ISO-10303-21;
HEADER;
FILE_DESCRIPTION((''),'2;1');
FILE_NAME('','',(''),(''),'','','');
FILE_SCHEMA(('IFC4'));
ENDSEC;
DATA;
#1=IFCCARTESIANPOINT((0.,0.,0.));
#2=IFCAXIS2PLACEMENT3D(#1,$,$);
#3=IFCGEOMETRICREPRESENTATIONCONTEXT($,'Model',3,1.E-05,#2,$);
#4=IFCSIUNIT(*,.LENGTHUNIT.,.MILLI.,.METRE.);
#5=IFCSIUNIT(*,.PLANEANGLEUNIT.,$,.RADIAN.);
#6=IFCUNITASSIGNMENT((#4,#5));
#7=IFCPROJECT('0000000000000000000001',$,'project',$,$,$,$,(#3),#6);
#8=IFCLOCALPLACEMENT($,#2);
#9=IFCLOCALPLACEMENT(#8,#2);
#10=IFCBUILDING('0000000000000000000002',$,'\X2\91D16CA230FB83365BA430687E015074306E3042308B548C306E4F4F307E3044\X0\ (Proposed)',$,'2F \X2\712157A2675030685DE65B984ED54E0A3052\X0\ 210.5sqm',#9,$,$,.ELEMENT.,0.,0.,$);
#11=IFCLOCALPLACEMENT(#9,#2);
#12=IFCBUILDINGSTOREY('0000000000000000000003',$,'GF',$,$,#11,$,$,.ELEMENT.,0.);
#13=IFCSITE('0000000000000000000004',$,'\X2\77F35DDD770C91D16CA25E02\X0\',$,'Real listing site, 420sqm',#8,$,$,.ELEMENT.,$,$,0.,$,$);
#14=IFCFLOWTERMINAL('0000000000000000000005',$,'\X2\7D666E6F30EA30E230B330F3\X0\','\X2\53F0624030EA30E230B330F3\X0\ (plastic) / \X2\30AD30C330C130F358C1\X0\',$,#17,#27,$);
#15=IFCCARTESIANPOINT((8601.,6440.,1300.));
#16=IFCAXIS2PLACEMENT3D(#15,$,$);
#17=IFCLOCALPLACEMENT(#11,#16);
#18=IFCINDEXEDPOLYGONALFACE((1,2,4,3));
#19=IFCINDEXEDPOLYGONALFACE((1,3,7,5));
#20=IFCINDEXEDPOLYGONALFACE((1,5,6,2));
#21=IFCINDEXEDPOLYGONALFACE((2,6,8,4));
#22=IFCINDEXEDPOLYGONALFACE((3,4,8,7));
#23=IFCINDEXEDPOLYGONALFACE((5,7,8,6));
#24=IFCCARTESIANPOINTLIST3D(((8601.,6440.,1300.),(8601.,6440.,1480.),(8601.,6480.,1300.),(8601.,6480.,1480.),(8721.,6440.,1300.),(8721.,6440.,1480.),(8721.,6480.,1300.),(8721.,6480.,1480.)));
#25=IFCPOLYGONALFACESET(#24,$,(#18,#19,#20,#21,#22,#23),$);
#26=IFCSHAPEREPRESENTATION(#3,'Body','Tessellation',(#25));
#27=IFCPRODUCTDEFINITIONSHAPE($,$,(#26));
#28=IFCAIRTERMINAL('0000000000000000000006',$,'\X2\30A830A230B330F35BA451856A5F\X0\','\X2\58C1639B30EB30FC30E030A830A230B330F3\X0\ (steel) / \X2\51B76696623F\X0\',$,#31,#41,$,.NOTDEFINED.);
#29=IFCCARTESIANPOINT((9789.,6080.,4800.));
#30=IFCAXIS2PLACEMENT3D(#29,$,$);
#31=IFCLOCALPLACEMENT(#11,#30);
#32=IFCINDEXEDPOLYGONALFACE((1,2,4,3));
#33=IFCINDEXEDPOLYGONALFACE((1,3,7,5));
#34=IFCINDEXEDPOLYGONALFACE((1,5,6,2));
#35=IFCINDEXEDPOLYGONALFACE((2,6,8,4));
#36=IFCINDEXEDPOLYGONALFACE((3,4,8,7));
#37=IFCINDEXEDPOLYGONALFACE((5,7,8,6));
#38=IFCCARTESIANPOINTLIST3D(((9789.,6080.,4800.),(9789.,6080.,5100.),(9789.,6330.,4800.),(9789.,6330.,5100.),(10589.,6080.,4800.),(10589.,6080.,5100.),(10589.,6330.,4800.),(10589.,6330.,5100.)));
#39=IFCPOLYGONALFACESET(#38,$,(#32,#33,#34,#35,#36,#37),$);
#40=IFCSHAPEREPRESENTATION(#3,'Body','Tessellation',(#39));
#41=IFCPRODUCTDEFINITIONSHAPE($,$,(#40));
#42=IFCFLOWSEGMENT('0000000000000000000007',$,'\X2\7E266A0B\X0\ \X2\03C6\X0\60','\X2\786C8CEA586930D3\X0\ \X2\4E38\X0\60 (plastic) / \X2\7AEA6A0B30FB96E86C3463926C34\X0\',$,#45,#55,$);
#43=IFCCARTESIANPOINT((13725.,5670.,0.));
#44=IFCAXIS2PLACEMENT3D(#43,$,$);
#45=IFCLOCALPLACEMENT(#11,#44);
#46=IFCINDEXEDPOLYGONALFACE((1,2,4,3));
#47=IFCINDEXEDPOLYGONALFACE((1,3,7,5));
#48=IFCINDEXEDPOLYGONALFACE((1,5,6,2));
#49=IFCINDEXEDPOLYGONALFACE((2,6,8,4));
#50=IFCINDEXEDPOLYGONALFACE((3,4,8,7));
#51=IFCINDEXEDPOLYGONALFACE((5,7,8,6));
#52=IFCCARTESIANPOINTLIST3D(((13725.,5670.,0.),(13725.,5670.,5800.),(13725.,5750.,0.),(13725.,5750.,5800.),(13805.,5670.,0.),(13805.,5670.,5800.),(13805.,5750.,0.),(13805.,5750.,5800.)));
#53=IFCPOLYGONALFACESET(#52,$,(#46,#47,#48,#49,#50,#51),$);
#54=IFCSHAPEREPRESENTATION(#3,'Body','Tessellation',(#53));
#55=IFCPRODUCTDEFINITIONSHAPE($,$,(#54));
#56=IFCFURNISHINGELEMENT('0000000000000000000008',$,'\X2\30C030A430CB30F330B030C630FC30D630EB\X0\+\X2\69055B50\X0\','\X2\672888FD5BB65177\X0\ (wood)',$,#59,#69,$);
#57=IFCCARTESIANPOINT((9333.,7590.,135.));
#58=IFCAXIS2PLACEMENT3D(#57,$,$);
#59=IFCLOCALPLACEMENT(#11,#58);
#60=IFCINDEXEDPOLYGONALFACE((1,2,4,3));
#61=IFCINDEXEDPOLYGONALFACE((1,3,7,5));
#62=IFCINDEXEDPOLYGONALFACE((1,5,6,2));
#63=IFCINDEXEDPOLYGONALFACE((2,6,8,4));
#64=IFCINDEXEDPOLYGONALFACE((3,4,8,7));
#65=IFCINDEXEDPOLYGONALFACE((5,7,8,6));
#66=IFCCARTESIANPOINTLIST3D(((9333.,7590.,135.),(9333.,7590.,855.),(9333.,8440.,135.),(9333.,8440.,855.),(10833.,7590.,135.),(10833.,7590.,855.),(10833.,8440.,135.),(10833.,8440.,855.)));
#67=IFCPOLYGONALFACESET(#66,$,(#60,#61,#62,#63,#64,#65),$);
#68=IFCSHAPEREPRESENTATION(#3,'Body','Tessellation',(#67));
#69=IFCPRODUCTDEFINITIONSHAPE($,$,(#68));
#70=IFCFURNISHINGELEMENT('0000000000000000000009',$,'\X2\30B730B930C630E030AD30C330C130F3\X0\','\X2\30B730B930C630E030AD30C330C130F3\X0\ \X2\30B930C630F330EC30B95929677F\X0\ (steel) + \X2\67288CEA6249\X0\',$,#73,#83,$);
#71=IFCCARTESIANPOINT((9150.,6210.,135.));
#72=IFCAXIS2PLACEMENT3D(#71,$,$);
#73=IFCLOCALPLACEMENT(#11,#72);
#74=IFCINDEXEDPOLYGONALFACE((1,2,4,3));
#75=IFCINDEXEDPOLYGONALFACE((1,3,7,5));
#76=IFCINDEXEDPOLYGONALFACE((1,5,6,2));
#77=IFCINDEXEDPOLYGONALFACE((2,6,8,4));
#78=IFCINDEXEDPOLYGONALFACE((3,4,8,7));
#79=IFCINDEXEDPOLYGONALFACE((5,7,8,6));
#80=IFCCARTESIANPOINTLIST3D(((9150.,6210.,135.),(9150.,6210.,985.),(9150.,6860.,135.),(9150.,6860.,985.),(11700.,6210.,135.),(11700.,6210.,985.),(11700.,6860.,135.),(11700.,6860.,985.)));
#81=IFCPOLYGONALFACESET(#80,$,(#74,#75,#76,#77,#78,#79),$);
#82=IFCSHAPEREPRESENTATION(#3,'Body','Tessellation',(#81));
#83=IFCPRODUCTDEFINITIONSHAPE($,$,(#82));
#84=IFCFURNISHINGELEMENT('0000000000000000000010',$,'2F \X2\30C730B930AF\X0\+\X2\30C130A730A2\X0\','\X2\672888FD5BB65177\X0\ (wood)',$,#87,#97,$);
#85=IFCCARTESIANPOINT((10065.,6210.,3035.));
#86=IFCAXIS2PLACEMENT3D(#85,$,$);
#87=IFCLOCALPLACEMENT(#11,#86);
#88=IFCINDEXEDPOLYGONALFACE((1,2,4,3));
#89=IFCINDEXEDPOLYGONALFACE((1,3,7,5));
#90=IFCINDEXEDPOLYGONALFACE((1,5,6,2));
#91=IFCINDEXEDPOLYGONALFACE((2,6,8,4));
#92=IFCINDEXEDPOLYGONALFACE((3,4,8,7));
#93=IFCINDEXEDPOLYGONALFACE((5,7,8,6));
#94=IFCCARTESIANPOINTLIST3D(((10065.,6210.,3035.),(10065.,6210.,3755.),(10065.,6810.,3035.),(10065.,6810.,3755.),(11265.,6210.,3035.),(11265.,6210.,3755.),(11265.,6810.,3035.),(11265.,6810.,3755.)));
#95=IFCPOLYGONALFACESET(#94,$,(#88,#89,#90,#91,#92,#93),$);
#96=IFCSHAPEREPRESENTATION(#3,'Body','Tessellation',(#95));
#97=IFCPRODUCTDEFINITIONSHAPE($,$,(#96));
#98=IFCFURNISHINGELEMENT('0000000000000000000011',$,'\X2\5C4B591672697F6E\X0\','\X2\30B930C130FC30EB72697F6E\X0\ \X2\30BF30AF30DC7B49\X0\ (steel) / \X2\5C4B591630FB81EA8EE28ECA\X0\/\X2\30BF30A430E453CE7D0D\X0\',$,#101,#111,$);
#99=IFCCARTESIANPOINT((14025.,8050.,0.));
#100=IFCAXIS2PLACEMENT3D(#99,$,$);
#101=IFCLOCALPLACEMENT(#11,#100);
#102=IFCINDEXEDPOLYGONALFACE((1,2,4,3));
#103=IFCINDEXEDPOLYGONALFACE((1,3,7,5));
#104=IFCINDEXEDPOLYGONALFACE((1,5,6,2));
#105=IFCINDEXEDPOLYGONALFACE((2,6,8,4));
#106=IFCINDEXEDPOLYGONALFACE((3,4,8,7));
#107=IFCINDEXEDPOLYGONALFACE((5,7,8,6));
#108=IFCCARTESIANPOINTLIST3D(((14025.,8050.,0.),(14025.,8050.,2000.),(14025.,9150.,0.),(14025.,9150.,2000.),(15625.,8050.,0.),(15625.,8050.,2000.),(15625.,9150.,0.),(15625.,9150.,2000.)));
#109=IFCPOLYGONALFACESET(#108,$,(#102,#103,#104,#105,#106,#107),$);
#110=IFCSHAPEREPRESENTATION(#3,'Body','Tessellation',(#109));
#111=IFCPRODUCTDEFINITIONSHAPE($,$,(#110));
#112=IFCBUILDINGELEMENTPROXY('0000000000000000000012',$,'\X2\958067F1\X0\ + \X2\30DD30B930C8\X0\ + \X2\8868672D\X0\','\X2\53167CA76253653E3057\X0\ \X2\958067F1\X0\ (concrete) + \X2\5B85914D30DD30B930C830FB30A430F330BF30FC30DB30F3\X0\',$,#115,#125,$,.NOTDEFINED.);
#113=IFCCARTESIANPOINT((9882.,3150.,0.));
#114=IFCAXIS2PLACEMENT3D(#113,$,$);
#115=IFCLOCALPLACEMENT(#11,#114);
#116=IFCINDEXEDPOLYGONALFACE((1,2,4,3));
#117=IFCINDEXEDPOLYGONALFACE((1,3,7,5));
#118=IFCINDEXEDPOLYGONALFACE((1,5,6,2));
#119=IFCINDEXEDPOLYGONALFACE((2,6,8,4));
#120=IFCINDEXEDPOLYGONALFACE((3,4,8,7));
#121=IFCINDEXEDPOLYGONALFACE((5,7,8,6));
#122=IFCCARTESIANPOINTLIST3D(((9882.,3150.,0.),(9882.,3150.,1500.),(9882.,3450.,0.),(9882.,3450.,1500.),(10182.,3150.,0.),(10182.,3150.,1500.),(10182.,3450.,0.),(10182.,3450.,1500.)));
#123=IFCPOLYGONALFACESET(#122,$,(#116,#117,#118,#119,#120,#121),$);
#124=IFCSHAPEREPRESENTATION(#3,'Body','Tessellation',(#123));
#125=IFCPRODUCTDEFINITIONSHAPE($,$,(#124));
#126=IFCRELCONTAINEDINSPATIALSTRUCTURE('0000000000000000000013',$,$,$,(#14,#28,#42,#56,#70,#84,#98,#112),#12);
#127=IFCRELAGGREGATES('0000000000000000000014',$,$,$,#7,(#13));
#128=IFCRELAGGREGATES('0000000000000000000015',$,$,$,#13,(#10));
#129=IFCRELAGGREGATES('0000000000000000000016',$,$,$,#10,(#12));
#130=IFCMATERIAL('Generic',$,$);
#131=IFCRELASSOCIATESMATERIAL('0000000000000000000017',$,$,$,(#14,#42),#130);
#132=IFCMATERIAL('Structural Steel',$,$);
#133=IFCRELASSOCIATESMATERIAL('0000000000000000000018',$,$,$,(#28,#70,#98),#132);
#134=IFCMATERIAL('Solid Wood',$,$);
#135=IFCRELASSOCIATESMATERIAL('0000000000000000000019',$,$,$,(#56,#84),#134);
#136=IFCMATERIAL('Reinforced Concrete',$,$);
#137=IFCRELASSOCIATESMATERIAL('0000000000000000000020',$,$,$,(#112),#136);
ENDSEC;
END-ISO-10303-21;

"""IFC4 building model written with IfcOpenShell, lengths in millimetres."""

from ifc_helpers import new_model, si_unit, frame, frame_2d, origin, place, context, project, spatial, rectangle, extrude, material, element, save


model = new_model("IFC4")

# Units and contexts
model_context = context("Model", 3, precision=1e-05, world=origin())
ifc_project = project(units=[si_unit("LENGTHUNIT", "METRE", prefix="MILLI"), si_unit("PLANEANGLEUNIT", "RADIAN")], contexts=[model_context])

# Site, building, storey
site_placement = place(None, origin())
site = spatial("IfcSite", under=ifc_project, at=site_placement, Name="石川県金沢市", ObjectType="Real listing site, 420sqm", CompositionType="ELEMENT", RefElevation=0.0)
building_placement = place(site_placement, origin())
building = spatial("IfcBuilding", under=site, at=building_placement, Name="金沢・茶室と縁側のある和の住まい (Proposed)", ObjectType="2F 無垢材と左官仕上げ 210.5sqm", CompositionType="ELEMENT", ElevationOfRefHeight=0.0, ElevationOfTerrain=0.0)
storey_placement = place(building_placement, origin())
storey = spatial("IfcBuildingStorey", under=building, at=storey_placement, Name="GF", CompositionType="ELEMENT", Elevation=0.0)

# Shared definitions
ifc_material_1 = material(Name="Solid Wood")

# Shared definitions
ifc_material_2 = material(Name="Reinforced Concrete")

# Shared definitions
ifc_material_3 = material(Name="Structural Steel")

# Flow terminal
ifc_material_4 = material(Name="Generic")
flow_terminal_1_placement = place(storey_placement, frame((8601.0, 6440.0, 1300.0)))
element("IfcFlowTerminal", 1, at=flow_terminal_1_placement, inside=storey, material=ifc_material_4, Name="給湯リモコン", Description="台所リモコン (plastic) / キッチン壁", context=model_context, shape_type="SweptSolid", body=[
    extrude(rectangle(XDim=120.0, YDim=40.0, at=frame_2d((60.0, 20.0))), frame((8601.0, 6440.0, 1300.0)), (0.0, 0.0, 1.0), 180.0),
])

# Air terminal
air_terminal_placement = place(storey_placement, frame((9789.0, 6080.0, 4800.0)))
element("IfcAirTerminal", 2, at=air_terminal_placement, inside=storey, material=ifc_material_3, Name="エアコン室内機", Description="壁掛ルームエアコン (steel) / 冷暖房", PredefinedType="NOTDEFINED", context=model_context, shape_type="SweptSolid", body=[
    extrude(rectangle(XDim=800.0, YDim=250.0, at=frame_2d((400.0, 125.0))), frame((9789.0, 6080.0, 4800.0)), (0.0, 0.0, 1.0), 300.0),
])

# Flow segment
flow_segment_placement = place(storey_placement, frame((13725.0, 5670.0, 0.0)))
element("IfcFlowSegment", 3, at=flow_segment_placement, inside=storey, material=ifc_material_4, Name="縦樋 φ60", Description="硬質塩ビ 丸60 (plastic) / 竪樋・雨水排水", context=model_context, shape_type="SweptSolid", body=[
    extrude(rectangle(XDim=80.0, YDim=80.0, at=frame_2d((40.0, 40.0))), frame((13725.0, 5670.0, 0.0)), (0.0, 0.0, 1.0), 5800.0),
])

# Furnishing elements
furnishing_1_placement = place(storey_placement, frame((9333.0, 7590.0, 135.0)))
element("IfcFurnishingElement", 4, at=furnishing_1_placement, inside=storey, material=ifc_material_1, Name="ダイニングテーブル+椅子", Description="木製家具 (wood)", context=model_context, shape_type="SweptSolid", body=[
    extrude(rectangle(XDim=1500.0, YDim=850.0, at=frame_2d((750.0, 425.0))), frame((9333.0, 7590.0, 135.0)), (0.0, 0.0, 1.0), 720.0),
])
furnishing_2_placement = place(storey_placement, frame((9150.0, 6210.0, 135.0)))
element("IfcFurnishingElement", 5, at=furnishing_2_placement, inside=storey, material=ifc_material_3, Name="システムキッチン", Description="システムキッチン ステンレス天板 (steel) + 木質扉", context=model_context, shape_type="SweptSolid", body=[
    extrude(rectangle(XDim=2550.0, YDim=650.0, at=frame_2d((1275.0, 325.0))), frame((9150.0, 6210.0, 135.0)), (0.0, 0.0, 1.0), 850.0),
])
furnishing_3_placement = place(storey_placement, frame((10065.0, 6210.0, 3035.0)))
element("IfcFurnishingElement", 6, at=furnishing_3_placement, inside=storey, material=ifc_material_1, Name="2F デスク+チェア", Description="木製家具 (wood)", context=model_context, shape_type="SweptSolid", body=[
    extrude(rectangle(XDim=1200.0, YDim=600.0, at=frame_2d((600.0, 300.0))), frame((10065.0, 6210.0, 3035.0)), (0.0, 0.0, 1.0), 720.0),
])
furnishing_4_placement = place(storey_placement, frame((14025.0, 8050.0, 0.0)))
element("IfcFurnishingElement", 7, at=furnishing_4_placement, inside=storey, material=ifc_material_3, Name="屋外物置", Description="スチール物置 タクボ等 (steel) / 屋外・自転車/タイヤ収納", context=model_context, shape_type="SweptSolid", body=[
    extrude(rectangle(XDim=1600.0, YDim=1100.0, at=frame_2d((800.0, 550.0))), frame((14025.0, 8050.0, 0.0)), (0.0, 0.0, 1.0), 2000.0),
])

# Building element proxy
proxy_placement = place(storey_placement, frame((9882.0, 3150.0, 0.0)))
element("IfcBuildingElementProxy", 8, at=proxy_placement, inside=storey, material=ifc_material_2, Name="門柱 + ポスト + 表札", Description="化粧打放し 門柱 (concrete) + 宅配ポスト・インターホン", PredefinedType="NOTDEFINED", context=model_context, shape_type="SweptSolid", body=[
    extrude(rectangle(XDim=300.0, YDim=300.0, at=frame_2d((150.0, 150.0))), frame((9882.0, 3150.0, 0.0)), (0.0, 0.0, 1.0), 1500.0),
])

save(model, "model.ifc")
